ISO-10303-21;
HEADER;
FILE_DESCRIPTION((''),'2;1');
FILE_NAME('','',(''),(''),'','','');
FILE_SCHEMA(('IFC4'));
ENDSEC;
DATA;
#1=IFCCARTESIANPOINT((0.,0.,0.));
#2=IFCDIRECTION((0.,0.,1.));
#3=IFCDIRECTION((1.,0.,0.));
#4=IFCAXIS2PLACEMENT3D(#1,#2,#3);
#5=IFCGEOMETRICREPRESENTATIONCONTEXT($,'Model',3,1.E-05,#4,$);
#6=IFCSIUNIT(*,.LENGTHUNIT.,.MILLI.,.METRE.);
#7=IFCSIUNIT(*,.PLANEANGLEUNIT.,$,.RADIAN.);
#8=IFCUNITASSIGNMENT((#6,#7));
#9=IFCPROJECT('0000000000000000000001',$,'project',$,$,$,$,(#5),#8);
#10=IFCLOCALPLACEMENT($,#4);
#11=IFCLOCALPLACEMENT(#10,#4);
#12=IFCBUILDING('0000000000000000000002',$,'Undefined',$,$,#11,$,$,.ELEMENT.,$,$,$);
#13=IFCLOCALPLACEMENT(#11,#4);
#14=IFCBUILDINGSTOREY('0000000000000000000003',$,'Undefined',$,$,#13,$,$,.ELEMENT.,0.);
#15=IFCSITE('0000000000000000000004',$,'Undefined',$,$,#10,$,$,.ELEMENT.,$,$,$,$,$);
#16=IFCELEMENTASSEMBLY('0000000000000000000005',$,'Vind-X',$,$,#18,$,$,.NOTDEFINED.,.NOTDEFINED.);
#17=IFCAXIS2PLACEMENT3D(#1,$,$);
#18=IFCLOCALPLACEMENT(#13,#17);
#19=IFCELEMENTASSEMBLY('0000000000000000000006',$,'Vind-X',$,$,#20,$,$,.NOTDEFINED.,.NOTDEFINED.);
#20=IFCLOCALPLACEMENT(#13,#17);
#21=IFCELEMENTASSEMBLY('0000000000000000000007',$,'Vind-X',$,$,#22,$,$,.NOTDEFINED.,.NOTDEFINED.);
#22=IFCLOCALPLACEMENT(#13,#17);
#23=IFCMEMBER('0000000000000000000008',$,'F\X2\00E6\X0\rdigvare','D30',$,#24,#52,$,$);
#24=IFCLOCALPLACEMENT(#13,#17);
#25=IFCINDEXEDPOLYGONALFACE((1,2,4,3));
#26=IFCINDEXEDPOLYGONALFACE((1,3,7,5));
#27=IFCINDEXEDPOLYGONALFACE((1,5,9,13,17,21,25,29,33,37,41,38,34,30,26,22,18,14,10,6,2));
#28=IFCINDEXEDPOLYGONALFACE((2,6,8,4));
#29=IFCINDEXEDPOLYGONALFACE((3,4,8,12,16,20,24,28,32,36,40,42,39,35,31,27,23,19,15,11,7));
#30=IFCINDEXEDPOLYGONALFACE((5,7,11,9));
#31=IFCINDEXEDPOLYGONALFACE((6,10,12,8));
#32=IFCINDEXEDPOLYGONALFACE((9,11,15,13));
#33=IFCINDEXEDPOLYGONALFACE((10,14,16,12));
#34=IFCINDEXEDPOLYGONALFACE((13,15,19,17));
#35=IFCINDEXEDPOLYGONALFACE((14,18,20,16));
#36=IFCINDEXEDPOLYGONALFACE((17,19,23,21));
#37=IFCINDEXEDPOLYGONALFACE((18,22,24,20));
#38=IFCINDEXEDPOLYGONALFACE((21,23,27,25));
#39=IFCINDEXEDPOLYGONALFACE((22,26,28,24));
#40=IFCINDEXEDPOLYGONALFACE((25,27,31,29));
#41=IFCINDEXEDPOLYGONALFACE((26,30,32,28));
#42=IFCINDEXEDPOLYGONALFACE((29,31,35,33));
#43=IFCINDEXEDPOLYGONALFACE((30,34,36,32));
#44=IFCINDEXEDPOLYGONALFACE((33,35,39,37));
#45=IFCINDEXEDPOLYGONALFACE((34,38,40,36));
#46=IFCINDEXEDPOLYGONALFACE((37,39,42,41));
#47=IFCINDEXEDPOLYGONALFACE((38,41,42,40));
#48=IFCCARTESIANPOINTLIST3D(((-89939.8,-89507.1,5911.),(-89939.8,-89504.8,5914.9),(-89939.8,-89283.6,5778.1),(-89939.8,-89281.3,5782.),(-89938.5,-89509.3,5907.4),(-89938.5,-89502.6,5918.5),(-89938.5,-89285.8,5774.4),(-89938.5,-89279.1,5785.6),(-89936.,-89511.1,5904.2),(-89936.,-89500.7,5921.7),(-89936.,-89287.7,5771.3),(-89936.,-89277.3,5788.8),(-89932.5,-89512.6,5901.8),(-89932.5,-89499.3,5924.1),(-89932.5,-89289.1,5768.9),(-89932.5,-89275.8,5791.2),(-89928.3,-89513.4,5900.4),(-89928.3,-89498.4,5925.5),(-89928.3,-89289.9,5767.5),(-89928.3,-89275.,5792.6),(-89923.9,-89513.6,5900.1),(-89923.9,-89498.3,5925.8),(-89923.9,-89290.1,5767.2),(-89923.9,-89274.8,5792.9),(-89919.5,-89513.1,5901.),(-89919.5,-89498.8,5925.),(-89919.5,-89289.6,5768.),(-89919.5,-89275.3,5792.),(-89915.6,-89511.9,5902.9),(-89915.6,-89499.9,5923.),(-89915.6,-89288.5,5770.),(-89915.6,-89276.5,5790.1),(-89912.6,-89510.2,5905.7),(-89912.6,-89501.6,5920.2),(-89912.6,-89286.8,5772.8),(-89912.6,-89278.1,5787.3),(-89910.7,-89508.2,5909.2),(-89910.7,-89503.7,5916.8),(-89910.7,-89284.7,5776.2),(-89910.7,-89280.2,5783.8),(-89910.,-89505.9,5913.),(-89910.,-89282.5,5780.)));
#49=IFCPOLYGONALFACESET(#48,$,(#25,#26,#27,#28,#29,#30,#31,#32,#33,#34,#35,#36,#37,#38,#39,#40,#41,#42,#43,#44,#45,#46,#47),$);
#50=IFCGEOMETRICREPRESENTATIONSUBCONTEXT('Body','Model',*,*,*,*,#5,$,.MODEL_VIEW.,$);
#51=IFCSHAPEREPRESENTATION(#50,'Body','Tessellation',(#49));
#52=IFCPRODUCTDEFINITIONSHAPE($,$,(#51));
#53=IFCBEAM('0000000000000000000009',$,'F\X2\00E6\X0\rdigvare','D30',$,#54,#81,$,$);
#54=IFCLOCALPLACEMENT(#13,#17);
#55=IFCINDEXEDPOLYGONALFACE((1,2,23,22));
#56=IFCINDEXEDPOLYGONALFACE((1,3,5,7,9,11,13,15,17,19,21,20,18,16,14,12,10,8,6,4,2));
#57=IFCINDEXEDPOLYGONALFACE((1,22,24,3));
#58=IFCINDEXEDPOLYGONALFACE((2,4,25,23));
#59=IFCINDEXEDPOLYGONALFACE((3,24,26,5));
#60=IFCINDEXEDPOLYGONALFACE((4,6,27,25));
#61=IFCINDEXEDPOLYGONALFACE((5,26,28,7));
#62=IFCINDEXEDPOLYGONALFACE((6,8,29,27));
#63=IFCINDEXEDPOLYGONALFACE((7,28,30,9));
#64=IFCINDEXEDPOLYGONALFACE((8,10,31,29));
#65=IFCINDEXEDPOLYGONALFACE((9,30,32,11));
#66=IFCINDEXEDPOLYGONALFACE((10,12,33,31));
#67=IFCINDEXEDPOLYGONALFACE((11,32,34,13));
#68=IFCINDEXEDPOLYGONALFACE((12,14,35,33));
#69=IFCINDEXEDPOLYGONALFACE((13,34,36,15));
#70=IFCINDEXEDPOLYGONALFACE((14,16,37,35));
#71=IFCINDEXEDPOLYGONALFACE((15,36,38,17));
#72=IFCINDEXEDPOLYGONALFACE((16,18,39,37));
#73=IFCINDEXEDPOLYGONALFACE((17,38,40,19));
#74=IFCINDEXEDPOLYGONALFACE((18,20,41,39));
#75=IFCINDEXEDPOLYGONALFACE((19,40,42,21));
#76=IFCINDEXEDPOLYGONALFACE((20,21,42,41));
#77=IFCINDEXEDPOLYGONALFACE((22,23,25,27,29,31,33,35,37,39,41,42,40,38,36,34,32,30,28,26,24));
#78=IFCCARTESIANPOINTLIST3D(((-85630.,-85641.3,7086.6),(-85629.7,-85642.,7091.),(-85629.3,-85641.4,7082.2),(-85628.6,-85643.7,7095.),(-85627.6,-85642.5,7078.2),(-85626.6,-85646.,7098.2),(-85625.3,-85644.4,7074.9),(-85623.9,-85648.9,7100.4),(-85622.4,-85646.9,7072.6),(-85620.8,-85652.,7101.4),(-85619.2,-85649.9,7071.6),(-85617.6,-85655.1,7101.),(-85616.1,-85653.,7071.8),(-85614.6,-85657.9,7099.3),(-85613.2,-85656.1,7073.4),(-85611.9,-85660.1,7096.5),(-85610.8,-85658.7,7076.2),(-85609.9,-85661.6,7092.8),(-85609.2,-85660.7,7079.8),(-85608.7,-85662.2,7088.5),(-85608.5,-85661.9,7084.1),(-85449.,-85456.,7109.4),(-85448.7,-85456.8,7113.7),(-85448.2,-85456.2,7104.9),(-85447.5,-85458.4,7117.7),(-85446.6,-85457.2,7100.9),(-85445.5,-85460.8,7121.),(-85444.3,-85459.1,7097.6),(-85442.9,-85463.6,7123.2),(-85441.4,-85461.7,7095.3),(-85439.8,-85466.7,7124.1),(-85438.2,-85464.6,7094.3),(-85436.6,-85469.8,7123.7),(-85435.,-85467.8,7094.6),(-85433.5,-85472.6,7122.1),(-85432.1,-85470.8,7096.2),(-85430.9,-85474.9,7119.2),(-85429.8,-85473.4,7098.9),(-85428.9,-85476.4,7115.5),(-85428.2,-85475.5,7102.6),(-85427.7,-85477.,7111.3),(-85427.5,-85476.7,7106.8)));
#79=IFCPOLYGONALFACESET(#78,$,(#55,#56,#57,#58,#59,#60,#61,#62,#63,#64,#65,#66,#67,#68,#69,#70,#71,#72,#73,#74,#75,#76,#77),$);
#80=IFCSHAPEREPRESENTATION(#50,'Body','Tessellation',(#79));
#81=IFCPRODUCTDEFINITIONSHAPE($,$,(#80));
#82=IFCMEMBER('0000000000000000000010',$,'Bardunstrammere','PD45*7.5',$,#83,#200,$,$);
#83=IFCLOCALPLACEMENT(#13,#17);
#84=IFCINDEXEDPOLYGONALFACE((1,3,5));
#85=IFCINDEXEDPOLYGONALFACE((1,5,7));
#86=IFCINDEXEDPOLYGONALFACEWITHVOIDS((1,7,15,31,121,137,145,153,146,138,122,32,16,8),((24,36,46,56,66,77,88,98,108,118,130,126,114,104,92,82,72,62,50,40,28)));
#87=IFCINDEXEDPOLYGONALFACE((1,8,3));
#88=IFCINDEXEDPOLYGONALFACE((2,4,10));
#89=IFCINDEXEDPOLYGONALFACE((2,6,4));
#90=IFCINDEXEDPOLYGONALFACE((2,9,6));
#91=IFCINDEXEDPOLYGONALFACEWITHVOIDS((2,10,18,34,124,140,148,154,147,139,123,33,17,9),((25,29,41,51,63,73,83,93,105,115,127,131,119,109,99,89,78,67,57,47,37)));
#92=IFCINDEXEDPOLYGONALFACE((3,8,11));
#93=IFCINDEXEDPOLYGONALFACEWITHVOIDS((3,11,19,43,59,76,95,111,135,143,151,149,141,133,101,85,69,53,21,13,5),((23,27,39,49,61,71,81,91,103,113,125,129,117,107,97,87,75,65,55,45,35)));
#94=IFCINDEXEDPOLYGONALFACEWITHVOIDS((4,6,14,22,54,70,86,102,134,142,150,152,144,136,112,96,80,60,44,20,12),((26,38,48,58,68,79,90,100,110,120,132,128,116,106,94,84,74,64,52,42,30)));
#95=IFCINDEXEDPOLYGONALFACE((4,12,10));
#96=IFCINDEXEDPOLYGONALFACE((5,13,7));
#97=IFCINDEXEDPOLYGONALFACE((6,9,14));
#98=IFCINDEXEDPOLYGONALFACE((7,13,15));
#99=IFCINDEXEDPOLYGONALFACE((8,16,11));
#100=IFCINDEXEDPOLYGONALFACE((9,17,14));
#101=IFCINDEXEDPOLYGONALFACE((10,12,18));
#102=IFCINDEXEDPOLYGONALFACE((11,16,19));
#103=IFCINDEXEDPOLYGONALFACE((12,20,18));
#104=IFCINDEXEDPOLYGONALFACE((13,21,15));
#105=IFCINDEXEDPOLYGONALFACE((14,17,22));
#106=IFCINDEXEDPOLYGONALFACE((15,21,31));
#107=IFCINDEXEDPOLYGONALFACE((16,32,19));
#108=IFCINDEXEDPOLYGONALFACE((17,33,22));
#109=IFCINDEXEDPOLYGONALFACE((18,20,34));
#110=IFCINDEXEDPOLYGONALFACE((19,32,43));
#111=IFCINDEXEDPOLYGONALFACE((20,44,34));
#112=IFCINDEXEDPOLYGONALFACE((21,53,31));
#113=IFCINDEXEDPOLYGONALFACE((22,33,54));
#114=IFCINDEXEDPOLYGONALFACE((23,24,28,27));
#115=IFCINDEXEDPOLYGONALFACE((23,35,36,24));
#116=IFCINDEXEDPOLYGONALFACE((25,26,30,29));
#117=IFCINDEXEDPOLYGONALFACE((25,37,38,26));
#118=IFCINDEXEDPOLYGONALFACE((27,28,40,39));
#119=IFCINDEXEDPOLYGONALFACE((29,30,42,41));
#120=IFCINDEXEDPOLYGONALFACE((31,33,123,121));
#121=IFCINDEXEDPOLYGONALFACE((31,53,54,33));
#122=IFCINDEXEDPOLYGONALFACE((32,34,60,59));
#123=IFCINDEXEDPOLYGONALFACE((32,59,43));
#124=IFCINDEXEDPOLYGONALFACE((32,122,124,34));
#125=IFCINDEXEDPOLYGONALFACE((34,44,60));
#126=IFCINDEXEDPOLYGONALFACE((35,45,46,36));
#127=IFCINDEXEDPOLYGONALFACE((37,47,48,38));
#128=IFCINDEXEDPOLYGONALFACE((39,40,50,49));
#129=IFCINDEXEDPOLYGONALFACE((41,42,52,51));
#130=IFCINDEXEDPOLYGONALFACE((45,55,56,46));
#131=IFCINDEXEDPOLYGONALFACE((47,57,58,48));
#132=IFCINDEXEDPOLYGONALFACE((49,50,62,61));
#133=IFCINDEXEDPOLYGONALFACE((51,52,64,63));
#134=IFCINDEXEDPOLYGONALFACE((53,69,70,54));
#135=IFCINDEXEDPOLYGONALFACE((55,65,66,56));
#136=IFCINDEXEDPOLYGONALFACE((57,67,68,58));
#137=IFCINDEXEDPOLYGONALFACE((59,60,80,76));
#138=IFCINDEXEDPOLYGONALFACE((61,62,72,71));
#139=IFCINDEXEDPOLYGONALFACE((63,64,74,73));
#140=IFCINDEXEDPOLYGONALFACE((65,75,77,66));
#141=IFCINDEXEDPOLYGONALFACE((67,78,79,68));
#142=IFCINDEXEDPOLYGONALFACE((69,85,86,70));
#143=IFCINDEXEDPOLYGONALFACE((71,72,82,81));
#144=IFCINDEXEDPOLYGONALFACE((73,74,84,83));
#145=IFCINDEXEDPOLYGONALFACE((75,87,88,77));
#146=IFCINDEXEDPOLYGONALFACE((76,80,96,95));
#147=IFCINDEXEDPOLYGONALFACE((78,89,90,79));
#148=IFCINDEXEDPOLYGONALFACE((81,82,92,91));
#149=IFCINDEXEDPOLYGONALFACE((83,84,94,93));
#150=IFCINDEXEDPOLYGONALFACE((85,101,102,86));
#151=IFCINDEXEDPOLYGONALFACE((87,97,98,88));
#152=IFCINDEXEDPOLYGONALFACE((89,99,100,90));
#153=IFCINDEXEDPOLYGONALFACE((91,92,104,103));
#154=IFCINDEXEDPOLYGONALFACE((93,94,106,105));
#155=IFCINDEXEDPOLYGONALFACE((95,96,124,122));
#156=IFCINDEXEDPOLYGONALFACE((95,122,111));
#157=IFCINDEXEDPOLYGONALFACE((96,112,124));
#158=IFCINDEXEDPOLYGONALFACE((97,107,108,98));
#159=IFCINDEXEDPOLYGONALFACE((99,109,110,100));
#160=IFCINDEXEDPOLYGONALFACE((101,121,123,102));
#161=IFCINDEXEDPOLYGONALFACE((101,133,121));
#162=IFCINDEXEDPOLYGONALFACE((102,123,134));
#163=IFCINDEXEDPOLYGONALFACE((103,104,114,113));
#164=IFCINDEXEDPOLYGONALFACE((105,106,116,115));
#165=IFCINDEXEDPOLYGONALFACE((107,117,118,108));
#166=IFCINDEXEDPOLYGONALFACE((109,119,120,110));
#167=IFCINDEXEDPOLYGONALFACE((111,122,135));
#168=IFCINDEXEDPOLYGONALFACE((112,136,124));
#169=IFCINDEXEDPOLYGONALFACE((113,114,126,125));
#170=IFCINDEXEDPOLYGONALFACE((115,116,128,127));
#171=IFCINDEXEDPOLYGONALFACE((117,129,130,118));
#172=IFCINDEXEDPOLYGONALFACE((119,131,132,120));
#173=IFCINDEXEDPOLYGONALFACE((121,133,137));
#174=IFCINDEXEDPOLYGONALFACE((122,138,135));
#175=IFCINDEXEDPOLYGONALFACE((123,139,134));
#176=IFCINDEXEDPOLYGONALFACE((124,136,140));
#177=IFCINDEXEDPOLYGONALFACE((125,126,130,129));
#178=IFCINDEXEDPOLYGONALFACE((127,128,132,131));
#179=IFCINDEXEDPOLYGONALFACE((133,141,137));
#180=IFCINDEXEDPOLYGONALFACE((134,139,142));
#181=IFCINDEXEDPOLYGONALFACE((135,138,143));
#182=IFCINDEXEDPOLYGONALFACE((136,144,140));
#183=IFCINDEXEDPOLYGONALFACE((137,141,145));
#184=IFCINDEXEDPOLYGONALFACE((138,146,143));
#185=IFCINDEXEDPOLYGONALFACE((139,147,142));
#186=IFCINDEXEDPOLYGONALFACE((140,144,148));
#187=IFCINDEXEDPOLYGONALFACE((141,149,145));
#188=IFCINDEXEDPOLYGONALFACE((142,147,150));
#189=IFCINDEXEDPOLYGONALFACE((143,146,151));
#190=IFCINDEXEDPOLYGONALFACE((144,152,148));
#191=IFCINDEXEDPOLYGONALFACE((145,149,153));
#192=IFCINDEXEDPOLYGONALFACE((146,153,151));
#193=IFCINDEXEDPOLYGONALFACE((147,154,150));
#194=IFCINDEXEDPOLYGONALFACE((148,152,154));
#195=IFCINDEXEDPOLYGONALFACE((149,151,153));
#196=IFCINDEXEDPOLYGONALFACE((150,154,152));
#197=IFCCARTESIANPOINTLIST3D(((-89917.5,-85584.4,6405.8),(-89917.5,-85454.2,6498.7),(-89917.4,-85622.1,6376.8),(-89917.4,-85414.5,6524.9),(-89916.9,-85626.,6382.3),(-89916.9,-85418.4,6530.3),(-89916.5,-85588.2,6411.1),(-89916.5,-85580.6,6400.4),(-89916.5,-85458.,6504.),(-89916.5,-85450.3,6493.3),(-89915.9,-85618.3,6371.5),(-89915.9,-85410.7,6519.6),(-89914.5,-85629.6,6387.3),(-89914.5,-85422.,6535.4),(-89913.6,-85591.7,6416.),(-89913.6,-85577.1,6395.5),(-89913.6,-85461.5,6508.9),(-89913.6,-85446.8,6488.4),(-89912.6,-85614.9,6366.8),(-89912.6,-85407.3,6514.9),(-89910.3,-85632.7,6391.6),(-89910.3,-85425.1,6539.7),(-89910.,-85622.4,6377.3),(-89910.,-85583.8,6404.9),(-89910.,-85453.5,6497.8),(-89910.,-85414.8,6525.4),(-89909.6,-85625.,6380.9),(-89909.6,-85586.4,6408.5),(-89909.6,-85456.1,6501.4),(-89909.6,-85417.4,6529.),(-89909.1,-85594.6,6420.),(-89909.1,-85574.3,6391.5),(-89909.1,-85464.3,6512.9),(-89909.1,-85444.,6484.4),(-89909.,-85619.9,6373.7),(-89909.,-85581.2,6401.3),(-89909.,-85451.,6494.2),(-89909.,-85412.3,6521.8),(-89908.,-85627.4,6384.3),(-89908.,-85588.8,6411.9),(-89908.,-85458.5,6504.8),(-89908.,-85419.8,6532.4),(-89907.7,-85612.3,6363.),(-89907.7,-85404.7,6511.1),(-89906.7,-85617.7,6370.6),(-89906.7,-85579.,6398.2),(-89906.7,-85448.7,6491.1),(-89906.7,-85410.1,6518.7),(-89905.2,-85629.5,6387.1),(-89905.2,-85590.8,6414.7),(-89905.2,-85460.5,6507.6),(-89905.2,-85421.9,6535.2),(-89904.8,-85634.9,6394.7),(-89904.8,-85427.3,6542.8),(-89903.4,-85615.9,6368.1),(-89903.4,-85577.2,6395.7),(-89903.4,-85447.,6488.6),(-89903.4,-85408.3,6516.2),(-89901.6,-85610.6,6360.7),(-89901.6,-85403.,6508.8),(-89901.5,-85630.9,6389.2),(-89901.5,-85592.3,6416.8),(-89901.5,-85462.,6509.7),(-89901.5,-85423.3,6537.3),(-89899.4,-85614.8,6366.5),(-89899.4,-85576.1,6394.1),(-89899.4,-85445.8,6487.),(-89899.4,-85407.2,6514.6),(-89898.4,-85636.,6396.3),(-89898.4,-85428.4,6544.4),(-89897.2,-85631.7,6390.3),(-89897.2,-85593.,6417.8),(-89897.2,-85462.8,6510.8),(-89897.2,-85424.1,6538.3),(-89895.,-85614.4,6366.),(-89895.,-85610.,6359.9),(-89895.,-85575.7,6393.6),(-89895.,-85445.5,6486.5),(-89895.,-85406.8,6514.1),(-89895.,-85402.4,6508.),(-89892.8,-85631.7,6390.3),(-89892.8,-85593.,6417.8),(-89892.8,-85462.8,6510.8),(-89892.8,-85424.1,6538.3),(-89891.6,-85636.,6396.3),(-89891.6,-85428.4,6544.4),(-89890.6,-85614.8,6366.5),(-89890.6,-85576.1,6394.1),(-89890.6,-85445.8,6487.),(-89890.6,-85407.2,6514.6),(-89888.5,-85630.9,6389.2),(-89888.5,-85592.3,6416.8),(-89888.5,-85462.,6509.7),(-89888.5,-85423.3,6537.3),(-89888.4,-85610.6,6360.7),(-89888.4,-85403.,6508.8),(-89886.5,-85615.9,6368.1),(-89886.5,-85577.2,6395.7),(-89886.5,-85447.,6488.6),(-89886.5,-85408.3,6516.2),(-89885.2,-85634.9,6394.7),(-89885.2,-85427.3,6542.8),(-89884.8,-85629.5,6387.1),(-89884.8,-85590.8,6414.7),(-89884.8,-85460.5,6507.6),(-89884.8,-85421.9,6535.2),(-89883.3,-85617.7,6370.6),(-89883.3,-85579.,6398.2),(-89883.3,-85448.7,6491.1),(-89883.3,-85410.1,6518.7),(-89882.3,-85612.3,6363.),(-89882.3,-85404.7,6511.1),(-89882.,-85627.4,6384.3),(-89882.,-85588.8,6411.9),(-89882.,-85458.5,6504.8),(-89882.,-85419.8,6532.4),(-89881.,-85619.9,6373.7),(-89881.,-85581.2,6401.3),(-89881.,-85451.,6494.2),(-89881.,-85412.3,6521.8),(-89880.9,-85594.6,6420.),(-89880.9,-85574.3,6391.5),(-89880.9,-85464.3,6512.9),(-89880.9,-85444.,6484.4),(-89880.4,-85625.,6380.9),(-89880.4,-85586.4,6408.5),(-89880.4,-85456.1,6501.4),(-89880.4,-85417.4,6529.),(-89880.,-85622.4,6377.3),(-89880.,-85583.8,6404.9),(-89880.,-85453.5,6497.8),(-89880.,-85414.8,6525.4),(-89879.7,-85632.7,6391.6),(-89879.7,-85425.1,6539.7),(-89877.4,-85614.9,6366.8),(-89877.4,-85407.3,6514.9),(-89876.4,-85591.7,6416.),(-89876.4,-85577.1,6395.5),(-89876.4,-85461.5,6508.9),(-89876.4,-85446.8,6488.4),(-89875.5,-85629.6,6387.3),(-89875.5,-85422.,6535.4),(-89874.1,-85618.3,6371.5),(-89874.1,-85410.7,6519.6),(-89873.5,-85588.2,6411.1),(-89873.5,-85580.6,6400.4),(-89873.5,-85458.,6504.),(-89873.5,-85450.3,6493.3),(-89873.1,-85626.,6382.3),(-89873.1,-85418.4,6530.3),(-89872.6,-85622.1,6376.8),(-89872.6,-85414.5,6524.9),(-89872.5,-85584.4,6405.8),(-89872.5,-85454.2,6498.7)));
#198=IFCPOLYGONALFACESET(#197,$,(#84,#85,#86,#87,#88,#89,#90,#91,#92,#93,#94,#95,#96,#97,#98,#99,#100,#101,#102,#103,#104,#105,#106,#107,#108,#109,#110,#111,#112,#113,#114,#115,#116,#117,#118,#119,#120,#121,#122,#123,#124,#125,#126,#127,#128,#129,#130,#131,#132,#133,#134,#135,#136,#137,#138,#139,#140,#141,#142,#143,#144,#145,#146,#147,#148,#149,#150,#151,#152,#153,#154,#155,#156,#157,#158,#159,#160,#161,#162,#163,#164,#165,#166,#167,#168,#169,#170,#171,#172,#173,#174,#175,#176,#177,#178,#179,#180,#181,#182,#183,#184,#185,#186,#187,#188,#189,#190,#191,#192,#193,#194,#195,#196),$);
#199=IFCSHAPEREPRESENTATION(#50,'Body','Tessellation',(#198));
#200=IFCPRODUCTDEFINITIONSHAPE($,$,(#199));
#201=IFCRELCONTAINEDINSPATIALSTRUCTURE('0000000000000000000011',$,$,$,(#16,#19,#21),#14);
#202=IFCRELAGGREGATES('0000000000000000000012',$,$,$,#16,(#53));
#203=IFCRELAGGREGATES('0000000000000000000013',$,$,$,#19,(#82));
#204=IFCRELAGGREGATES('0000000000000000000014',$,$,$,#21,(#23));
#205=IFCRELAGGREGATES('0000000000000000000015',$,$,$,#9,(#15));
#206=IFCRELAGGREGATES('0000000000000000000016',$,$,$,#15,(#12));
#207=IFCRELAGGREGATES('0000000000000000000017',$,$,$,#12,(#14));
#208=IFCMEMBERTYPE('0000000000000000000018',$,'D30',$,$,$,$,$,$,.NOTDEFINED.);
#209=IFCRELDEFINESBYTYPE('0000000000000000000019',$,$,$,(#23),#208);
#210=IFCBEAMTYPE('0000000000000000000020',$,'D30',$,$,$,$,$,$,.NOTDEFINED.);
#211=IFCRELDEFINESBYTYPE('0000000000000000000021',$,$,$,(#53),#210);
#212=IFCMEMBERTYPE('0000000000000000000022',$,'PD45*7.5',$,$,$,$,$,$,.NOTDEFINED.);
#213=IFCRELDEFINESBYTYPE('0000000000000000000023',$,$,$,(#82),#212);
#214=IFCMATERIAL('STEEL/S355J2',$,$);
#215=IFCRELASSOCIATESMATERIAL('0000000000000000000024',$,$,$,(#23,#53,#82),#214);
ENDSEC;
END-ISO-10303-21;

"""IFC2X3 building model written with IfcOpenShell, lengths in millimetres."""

from ifc_helpers import new_model, si_unit, frame, origin_with_axes, origin_2d_with_axis, place, context, subcontext, project, spatial, rectangle, circle, hollow_circle, extrude, boolean, material, type_object, element, aggregate, save


model = new_model("IFC2X3")

# Units and contexts
model_context = context("Model", 3, precision=1e-05, world=origin_with_axes())
body_context = subcontext(model_context, "Body", "Model", "MODEL_VIEW")
ifc_project = project(units=[si_unit("LENGTHUNIT", "METRE", prefix="MILLI"), si_unit("PLANEANGLEUNIT", "RADIAN")], contexts=[model_context])

# Site, building, storey
site_placement = place(None, origin_with_axes())
site = spatial("IfcSite", under=ifc_project, at=site_placement, Name="Undefined", CompositionType="ELEMENT")
building_placement = place(site_placement, origin_with_axes())
building = spatial("IfcBuilding", under=site, at=building_placement, Name="Undefined", CompositionType="ELEMENT")
storey_placement = place(building_placement, origin_with_axes())
storey = spatial("IfcBuildingStorey", under=building, at=storey_placement, Name="Undefined", CompositionType="ELEMENT", Elevation=0.0)

# Element assembly
assembly_1_placement = place(storey_placement, origin_with_axes())
assembly_1 = element("IfcElementAssembly", 1, at=assembly_1_placement, inside=storey, Name="Vind-X", AssemblyPlace="NOTDEFINED", PredefinedType="NOTDEFINED")
ifc_material_1 = material(Name="STEEL/S355J2")

# Shared definitions
member_type_1 = type_object("IfcMemberType", Name="D30", PredefinedType="NOTDEFINED")

# Element assemblies, member
assembly_2_placement = place(storey_placement, origin_with_axes())
assembly_2 = element("IfcElementAssembly", 2, at=assembly_2_placement, inside=storey, Name="Vind-X", AssemblyPlace="NOTDEFINED", PredefinedType="NOTDEFINED")
assembly_3_placement = place(storey_placement, origin_with_axes())
assembly_3 = element("IfcElementAssembly", 3, at=assembly_3_placement, inside=storey, Name="Vind-X", AssemblyPlace="NOTDEFINED", PredefinedType="NOTDEFINED")
member_1_placement = place(assembly_3_placement, frame((-89925.0, -89505.9, 5913.0), z_axis=(0.0, 0.511223, 0.859448), x_axis=(0.0, 0.859448, -0.511223)))
member_1 = element("IfcMember", 4, at=member_1_placement, type_object=member_type_1, material=ifc_material_1, Name="Færdigvare", Description="D30", context=body_context, shape_type="SweptSolid", body=[
    extrude(circle(Radius=15.0, at=origin_2d_with_axis()), frame((260.0, 0.0, 0.0), z_axis=(-1.0, 0.0, 0.0), x_axis=(0.0, -1.0, 0.0)), (0.0, 0.0, 1.0), 260.0),
])

# Beam
beam_type_1 = type_object("IfcBeamType", Name="D30", PredefinedType="NOTDEFINED")
beam_1_placement = place(assembly_1_placement, frame((-85438.2, -85466.5, 7109.2), z_axis=(-0.717841, 0.691017, 0.084846), x_axis=(-0.696207, -0.712491, -0.087483)))
beam_1 = element("IfcBeam", 5, at=beam_1_placement, type_object=beam_type_1, material=ifc_material_1, Name="Færdigvare", Description="D30", context=body_context, shape_type="SweptSolid", body=[
    extrude(circle(Radius=15.0, at=origin_2d_with_axis()), frame((260.0, 0.0, 0.0), z_axis=(-1.0, 0.0, 0.0), x_axis=(0.0, -1.0, 0.0)), (0.0, 0.0, 1.0), 260.0),
])
aggregate(assembly_1, [beam_1])

# Member
member_type_2 = type_object("IfcMemberType", Name="PD45*7.5", PredefinedType="NOTDEFINED")
member_2_placement = place(assembly_2_placement, frame((-89895.0, -85415.5, 6526.3), z_axis=(-1.0, 0.0, 0.0), x_axis=(0.0, -0.814089, -0.58074)))
member_2 = element("IfcMember", 6, at=member_2_placement, type_object=member_type_2, material=ifc_material_1, Name="Bardunstrammere", Description="PD45*7.5", context=body_context, shape_type="CSG", body=[
    boolean("DIFFERENCE", extrude(hollow_circle(Radius=22.5, WallThickness=7.5, at=origin_2d_with_axis()), frame((255.0, 0.0, 0.0), z_axis=(-1.0, 0.0, 0.0), x_axis=(0.0, -1.0, 0.0)), (0.0, 0.0, 1.0), 255.0), extrude(rectangle(XDim=35.0, YDim=90.0, at=origin_2d_with_axis()), frame((207.5, 0.0, 0.0), z_axis=(-1.0, 0.0, 0.0), x_axis=(0.0, -1.0, 0.0)), (0.0, 0.0, 1.0), 160.0)),
])

aggregate(assembly_2, [member_2])
aggregate(assembly_3, [member_1])

save(model, "model.ifc")
